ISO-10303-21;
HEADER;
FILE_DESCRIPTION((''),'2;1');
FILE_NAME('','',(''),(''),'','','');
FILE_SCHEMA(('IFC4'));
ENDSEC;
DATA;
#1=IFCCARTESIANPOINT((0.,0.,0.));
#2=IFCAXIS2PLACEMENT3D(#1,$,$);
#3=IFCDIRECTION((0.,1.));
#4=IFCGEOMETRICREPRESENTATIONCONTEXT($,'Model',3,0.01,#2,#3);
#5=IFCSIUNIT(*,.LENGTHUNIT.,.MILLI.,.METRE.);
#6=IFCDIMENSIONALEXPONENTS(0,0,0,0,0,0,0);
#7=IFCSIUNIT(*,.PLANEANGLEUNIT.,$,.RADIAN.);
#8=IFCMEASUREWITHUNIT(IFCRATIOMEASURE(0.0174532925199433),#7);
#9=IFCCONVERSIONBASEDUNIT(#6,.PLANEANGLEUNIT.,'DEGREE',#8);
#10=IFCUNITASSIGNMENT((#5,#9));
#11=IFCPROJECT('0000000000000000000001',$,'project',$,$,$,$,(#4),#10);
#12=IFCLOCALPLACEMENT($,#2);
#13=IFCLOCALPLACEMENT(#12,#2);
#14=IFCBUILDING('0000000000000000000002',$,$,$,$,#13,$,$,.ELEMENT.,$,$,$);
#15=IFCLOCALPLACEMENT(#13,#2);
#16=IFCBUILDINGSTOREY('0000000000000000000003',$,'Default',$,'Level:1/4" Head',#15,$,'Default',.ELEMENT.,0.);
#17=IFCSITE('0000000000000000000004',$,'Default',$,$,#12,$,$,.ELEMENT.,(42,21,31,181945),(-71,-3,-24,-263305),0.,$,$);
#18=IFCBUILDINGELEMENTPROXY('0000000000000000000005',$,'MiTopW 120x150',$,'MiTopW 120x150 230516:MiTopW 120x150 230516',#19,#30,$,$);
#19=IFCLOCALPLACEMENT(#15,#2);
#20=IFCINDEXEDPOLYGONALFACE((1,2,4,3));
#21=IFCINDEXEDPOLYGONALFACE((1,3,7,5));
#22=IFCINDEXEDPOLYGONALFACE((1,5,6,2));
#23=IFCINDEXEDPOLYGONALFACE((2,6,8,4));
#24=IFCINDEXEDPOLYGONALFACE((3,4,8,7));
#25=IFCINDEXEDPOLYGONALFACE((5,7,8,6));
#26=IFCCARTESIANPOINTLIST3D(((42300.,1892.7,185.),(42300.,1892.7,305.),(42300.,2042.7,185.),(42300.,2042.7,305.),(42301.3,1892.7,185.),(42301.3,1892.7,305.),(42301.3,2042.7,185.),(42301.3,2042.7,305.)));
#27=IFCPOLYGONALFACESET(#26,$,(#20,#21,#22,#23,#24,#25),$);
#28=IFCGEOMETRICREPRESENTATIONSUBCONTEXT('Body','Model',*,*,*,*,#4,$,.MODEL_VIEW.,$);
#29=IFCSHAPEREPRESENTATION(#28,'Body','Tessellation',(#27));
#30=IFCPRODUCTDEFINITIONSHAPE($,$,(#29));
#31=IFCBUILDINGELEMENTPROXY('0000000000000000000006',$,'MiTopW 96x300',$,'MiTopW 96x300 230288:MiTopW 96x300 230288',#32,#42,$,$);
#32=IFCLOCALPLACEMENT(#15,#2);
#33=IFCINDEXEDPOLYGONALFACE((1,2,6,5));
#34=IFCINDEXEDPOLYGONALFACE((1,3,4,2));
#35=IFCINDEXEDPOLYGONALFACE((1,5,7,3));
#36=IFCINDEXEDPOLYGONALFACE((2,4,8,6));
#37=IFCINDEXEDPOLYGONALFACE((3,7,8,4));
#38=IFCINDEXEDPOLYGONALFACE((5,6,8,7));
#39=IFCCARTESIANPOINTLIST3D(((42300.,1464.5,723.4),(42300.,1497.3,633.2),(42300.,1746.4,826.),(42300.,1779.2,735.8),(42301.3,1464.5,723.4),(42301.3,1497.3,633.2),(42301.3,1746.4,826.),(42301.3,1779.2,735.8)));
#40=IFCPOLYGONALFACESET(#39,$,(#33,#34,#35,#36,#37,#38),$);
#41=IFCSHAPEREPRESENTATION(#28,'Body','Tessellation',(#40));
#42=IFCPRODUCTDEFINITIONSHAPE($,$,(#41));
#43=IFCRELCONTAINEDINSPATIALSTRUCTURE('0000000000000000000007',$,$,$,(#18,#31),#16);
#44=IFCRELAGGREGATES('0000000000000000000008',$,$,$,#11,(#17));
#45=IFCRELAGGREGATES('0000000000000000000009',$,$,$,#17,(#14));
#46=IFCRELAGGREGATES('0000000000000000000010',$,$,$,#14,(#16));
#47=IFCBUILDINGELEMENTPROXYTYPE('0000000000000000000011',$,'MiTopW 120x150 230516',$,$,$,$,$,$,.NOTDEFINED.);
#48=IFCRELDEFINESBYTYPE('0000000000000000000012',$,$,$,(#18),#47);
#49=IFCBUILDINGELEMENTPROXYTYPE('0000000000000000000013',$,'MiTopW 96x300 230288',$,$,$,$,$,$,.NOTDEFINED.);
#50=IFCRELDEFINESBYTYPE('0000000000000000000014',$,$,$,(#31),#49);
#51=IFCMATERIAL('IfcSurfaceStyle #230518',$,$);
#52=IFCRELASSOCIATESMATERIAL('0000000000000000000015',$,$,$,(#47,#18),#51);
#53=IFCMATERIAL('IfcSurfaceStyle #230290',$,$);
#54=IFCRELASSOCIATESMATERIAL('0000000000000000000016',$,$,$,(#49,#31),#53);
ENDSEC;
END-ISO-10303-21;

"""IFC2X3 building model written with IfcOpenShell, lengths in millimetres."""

from ifc_helpers import new_model, entity, si_unit, converted_unit, direction, frame, origin, origin_2d_with_axis, place, context, subcontext, project, spatial, polyline, rectangle, outline, extrude, source, transform, mapped, material, type_object, type_shapes, element, save


model = new_model("IFC2X3")

# Units and contexts
model_context = context("Model", 3, precision=0.01, world=origin(), true_north=direction((0.0, 1.0)))
body_context = subcontext(model_context, "Body", "Model", "MODEL_VIEW")
ifc_project = project(units=[si_unit("LENGTHUNIT", "METRE", prefix="MILLI"), converted_unit("PLANEANGLEUNIT", "DEGREE", entity("IfcRatioMeasure", 0.0174532925199433), si_unit("PLANEANGLEUNIT", "RADIAN"), dimensions=[0, 0, 0, 0, 0, 0, 0])], contexts=[model_context])

# Site, building, storey
site_placement = place(None, origin())
site = spatial("IfcSite", under=ifc_project, at=site_placement, Name="Default", CompositionType="ELEMENT", RefLatitude=(42, 21, 31, 181945), RefLongitude=(-71, -3, -24, -263305), RefElevation=0.0)
building_placement = place(site_placement, origin())
building = spatial("IfcBuilding", under=site, at=building_placement, CompositionType="ELEMENT")
storey_placement = place(building_placement, origin())
storey = spatial("IfcBuildingStorey", under=building, at=storey_placement, Name="Default", ObjectType="Level:1/4\" Head", LongName="Default", CompositionType="ELEMENT", Elevation=0.0)

# Building element proxies
ifc_material_1 = material(Name="IfcSurfaceStyle #230518")
building_element_proxy_type_1 = type_object("IfcBuildingElementProxyType", Name="MiTopW 120x150 230516", PredefinedType="NOTDEFINED", material=ifc_material_1)
shared_shape_1 = source(origin(), body_context, "Body", "SweptSolid", [
    extrude(rectangle(XDim=150.0, YDim=120.0, at=origin_2d_with_axis()), frame((75.0, 60.0, 0.0), z_axis=(0.0, 0.0, 1.0), x_axis=(-1.0, 0.0, 0.0)), (0.0, 0.0, 1.0), 1.3),
])
type_shapes(building_element_proxy_type_1, [shared_shape_1])
proxy_1_placement = place(building_placement, frame((42301.3, 1892.7, 305.0), z_axis=(-1.0, 0.0, 0.0), x_axis=(0.0, 1.0, 0.0)))
element("IfcBuildingElementProxy", 1, at=proxy_1_placement, inside=storey, type_object=building_element_proxy_type_1, material=ifc_material_1, Name="MiTopW 120x150", ObjectType="MiTopW 120x150 230516:MiTopW 120x150 230516", context=body_context, shape_type="MappedRepresentation", body=[
    mapped(shared_shape_1, transform((0.0, 0.0, 0.0), scale=1.0)),
])
ifc_material_2 = material(Name="IfcSurfaceStyle #230290")
building_element_proxy_type_2 = type_object("IfcBuildingElementProxyType", Name="MiTopW 96x300 230288", PredefinedType="NOTDEFINED", material=ifc_material_2)
shared_shape_2 = source(origin(), body_context, "Body", "SweptSolid", [
    extrude(outline(polyline([(-150.0, -48.0), (150.0, -48.0), (150.0, 48.0), (-150.0, 48.0), (-150.0, -48.0)])), frame((150.0, 48.0, 0.0), z_axis=(0.0, 0.0, 1.0), x_axis=(-1.0, 0.0, 0.0)), (0.0, 0.0, 1.0), 1.3),
])
type_shapes(building_element_proxy_type_2, [shared_shape_2])
proxy_2_placement = place(building_placement, frame((42301.3, 1464.5, 723.4), z_axis=(-1.0, 0.0, 0.0), x_axis=(0.0, 0.939693, 0.34202)))
element("IfcBuildingElementProxy", 2, at=proxy_2_placement, inside=storey, type_object=building_element_proxy_type_2, material=ifc_material_2, Name="MiTopW 96x300", ObjectType="MiTopW 96x300 230288:MiTopW 96x300 230288", context=body_context, shape_type="MappedRepresentation", body=[
    mapped(shared_shape_2, transform((0.0, 0.0, 0.0), scale=1.0)),
])

save(model, "model.ifc")
